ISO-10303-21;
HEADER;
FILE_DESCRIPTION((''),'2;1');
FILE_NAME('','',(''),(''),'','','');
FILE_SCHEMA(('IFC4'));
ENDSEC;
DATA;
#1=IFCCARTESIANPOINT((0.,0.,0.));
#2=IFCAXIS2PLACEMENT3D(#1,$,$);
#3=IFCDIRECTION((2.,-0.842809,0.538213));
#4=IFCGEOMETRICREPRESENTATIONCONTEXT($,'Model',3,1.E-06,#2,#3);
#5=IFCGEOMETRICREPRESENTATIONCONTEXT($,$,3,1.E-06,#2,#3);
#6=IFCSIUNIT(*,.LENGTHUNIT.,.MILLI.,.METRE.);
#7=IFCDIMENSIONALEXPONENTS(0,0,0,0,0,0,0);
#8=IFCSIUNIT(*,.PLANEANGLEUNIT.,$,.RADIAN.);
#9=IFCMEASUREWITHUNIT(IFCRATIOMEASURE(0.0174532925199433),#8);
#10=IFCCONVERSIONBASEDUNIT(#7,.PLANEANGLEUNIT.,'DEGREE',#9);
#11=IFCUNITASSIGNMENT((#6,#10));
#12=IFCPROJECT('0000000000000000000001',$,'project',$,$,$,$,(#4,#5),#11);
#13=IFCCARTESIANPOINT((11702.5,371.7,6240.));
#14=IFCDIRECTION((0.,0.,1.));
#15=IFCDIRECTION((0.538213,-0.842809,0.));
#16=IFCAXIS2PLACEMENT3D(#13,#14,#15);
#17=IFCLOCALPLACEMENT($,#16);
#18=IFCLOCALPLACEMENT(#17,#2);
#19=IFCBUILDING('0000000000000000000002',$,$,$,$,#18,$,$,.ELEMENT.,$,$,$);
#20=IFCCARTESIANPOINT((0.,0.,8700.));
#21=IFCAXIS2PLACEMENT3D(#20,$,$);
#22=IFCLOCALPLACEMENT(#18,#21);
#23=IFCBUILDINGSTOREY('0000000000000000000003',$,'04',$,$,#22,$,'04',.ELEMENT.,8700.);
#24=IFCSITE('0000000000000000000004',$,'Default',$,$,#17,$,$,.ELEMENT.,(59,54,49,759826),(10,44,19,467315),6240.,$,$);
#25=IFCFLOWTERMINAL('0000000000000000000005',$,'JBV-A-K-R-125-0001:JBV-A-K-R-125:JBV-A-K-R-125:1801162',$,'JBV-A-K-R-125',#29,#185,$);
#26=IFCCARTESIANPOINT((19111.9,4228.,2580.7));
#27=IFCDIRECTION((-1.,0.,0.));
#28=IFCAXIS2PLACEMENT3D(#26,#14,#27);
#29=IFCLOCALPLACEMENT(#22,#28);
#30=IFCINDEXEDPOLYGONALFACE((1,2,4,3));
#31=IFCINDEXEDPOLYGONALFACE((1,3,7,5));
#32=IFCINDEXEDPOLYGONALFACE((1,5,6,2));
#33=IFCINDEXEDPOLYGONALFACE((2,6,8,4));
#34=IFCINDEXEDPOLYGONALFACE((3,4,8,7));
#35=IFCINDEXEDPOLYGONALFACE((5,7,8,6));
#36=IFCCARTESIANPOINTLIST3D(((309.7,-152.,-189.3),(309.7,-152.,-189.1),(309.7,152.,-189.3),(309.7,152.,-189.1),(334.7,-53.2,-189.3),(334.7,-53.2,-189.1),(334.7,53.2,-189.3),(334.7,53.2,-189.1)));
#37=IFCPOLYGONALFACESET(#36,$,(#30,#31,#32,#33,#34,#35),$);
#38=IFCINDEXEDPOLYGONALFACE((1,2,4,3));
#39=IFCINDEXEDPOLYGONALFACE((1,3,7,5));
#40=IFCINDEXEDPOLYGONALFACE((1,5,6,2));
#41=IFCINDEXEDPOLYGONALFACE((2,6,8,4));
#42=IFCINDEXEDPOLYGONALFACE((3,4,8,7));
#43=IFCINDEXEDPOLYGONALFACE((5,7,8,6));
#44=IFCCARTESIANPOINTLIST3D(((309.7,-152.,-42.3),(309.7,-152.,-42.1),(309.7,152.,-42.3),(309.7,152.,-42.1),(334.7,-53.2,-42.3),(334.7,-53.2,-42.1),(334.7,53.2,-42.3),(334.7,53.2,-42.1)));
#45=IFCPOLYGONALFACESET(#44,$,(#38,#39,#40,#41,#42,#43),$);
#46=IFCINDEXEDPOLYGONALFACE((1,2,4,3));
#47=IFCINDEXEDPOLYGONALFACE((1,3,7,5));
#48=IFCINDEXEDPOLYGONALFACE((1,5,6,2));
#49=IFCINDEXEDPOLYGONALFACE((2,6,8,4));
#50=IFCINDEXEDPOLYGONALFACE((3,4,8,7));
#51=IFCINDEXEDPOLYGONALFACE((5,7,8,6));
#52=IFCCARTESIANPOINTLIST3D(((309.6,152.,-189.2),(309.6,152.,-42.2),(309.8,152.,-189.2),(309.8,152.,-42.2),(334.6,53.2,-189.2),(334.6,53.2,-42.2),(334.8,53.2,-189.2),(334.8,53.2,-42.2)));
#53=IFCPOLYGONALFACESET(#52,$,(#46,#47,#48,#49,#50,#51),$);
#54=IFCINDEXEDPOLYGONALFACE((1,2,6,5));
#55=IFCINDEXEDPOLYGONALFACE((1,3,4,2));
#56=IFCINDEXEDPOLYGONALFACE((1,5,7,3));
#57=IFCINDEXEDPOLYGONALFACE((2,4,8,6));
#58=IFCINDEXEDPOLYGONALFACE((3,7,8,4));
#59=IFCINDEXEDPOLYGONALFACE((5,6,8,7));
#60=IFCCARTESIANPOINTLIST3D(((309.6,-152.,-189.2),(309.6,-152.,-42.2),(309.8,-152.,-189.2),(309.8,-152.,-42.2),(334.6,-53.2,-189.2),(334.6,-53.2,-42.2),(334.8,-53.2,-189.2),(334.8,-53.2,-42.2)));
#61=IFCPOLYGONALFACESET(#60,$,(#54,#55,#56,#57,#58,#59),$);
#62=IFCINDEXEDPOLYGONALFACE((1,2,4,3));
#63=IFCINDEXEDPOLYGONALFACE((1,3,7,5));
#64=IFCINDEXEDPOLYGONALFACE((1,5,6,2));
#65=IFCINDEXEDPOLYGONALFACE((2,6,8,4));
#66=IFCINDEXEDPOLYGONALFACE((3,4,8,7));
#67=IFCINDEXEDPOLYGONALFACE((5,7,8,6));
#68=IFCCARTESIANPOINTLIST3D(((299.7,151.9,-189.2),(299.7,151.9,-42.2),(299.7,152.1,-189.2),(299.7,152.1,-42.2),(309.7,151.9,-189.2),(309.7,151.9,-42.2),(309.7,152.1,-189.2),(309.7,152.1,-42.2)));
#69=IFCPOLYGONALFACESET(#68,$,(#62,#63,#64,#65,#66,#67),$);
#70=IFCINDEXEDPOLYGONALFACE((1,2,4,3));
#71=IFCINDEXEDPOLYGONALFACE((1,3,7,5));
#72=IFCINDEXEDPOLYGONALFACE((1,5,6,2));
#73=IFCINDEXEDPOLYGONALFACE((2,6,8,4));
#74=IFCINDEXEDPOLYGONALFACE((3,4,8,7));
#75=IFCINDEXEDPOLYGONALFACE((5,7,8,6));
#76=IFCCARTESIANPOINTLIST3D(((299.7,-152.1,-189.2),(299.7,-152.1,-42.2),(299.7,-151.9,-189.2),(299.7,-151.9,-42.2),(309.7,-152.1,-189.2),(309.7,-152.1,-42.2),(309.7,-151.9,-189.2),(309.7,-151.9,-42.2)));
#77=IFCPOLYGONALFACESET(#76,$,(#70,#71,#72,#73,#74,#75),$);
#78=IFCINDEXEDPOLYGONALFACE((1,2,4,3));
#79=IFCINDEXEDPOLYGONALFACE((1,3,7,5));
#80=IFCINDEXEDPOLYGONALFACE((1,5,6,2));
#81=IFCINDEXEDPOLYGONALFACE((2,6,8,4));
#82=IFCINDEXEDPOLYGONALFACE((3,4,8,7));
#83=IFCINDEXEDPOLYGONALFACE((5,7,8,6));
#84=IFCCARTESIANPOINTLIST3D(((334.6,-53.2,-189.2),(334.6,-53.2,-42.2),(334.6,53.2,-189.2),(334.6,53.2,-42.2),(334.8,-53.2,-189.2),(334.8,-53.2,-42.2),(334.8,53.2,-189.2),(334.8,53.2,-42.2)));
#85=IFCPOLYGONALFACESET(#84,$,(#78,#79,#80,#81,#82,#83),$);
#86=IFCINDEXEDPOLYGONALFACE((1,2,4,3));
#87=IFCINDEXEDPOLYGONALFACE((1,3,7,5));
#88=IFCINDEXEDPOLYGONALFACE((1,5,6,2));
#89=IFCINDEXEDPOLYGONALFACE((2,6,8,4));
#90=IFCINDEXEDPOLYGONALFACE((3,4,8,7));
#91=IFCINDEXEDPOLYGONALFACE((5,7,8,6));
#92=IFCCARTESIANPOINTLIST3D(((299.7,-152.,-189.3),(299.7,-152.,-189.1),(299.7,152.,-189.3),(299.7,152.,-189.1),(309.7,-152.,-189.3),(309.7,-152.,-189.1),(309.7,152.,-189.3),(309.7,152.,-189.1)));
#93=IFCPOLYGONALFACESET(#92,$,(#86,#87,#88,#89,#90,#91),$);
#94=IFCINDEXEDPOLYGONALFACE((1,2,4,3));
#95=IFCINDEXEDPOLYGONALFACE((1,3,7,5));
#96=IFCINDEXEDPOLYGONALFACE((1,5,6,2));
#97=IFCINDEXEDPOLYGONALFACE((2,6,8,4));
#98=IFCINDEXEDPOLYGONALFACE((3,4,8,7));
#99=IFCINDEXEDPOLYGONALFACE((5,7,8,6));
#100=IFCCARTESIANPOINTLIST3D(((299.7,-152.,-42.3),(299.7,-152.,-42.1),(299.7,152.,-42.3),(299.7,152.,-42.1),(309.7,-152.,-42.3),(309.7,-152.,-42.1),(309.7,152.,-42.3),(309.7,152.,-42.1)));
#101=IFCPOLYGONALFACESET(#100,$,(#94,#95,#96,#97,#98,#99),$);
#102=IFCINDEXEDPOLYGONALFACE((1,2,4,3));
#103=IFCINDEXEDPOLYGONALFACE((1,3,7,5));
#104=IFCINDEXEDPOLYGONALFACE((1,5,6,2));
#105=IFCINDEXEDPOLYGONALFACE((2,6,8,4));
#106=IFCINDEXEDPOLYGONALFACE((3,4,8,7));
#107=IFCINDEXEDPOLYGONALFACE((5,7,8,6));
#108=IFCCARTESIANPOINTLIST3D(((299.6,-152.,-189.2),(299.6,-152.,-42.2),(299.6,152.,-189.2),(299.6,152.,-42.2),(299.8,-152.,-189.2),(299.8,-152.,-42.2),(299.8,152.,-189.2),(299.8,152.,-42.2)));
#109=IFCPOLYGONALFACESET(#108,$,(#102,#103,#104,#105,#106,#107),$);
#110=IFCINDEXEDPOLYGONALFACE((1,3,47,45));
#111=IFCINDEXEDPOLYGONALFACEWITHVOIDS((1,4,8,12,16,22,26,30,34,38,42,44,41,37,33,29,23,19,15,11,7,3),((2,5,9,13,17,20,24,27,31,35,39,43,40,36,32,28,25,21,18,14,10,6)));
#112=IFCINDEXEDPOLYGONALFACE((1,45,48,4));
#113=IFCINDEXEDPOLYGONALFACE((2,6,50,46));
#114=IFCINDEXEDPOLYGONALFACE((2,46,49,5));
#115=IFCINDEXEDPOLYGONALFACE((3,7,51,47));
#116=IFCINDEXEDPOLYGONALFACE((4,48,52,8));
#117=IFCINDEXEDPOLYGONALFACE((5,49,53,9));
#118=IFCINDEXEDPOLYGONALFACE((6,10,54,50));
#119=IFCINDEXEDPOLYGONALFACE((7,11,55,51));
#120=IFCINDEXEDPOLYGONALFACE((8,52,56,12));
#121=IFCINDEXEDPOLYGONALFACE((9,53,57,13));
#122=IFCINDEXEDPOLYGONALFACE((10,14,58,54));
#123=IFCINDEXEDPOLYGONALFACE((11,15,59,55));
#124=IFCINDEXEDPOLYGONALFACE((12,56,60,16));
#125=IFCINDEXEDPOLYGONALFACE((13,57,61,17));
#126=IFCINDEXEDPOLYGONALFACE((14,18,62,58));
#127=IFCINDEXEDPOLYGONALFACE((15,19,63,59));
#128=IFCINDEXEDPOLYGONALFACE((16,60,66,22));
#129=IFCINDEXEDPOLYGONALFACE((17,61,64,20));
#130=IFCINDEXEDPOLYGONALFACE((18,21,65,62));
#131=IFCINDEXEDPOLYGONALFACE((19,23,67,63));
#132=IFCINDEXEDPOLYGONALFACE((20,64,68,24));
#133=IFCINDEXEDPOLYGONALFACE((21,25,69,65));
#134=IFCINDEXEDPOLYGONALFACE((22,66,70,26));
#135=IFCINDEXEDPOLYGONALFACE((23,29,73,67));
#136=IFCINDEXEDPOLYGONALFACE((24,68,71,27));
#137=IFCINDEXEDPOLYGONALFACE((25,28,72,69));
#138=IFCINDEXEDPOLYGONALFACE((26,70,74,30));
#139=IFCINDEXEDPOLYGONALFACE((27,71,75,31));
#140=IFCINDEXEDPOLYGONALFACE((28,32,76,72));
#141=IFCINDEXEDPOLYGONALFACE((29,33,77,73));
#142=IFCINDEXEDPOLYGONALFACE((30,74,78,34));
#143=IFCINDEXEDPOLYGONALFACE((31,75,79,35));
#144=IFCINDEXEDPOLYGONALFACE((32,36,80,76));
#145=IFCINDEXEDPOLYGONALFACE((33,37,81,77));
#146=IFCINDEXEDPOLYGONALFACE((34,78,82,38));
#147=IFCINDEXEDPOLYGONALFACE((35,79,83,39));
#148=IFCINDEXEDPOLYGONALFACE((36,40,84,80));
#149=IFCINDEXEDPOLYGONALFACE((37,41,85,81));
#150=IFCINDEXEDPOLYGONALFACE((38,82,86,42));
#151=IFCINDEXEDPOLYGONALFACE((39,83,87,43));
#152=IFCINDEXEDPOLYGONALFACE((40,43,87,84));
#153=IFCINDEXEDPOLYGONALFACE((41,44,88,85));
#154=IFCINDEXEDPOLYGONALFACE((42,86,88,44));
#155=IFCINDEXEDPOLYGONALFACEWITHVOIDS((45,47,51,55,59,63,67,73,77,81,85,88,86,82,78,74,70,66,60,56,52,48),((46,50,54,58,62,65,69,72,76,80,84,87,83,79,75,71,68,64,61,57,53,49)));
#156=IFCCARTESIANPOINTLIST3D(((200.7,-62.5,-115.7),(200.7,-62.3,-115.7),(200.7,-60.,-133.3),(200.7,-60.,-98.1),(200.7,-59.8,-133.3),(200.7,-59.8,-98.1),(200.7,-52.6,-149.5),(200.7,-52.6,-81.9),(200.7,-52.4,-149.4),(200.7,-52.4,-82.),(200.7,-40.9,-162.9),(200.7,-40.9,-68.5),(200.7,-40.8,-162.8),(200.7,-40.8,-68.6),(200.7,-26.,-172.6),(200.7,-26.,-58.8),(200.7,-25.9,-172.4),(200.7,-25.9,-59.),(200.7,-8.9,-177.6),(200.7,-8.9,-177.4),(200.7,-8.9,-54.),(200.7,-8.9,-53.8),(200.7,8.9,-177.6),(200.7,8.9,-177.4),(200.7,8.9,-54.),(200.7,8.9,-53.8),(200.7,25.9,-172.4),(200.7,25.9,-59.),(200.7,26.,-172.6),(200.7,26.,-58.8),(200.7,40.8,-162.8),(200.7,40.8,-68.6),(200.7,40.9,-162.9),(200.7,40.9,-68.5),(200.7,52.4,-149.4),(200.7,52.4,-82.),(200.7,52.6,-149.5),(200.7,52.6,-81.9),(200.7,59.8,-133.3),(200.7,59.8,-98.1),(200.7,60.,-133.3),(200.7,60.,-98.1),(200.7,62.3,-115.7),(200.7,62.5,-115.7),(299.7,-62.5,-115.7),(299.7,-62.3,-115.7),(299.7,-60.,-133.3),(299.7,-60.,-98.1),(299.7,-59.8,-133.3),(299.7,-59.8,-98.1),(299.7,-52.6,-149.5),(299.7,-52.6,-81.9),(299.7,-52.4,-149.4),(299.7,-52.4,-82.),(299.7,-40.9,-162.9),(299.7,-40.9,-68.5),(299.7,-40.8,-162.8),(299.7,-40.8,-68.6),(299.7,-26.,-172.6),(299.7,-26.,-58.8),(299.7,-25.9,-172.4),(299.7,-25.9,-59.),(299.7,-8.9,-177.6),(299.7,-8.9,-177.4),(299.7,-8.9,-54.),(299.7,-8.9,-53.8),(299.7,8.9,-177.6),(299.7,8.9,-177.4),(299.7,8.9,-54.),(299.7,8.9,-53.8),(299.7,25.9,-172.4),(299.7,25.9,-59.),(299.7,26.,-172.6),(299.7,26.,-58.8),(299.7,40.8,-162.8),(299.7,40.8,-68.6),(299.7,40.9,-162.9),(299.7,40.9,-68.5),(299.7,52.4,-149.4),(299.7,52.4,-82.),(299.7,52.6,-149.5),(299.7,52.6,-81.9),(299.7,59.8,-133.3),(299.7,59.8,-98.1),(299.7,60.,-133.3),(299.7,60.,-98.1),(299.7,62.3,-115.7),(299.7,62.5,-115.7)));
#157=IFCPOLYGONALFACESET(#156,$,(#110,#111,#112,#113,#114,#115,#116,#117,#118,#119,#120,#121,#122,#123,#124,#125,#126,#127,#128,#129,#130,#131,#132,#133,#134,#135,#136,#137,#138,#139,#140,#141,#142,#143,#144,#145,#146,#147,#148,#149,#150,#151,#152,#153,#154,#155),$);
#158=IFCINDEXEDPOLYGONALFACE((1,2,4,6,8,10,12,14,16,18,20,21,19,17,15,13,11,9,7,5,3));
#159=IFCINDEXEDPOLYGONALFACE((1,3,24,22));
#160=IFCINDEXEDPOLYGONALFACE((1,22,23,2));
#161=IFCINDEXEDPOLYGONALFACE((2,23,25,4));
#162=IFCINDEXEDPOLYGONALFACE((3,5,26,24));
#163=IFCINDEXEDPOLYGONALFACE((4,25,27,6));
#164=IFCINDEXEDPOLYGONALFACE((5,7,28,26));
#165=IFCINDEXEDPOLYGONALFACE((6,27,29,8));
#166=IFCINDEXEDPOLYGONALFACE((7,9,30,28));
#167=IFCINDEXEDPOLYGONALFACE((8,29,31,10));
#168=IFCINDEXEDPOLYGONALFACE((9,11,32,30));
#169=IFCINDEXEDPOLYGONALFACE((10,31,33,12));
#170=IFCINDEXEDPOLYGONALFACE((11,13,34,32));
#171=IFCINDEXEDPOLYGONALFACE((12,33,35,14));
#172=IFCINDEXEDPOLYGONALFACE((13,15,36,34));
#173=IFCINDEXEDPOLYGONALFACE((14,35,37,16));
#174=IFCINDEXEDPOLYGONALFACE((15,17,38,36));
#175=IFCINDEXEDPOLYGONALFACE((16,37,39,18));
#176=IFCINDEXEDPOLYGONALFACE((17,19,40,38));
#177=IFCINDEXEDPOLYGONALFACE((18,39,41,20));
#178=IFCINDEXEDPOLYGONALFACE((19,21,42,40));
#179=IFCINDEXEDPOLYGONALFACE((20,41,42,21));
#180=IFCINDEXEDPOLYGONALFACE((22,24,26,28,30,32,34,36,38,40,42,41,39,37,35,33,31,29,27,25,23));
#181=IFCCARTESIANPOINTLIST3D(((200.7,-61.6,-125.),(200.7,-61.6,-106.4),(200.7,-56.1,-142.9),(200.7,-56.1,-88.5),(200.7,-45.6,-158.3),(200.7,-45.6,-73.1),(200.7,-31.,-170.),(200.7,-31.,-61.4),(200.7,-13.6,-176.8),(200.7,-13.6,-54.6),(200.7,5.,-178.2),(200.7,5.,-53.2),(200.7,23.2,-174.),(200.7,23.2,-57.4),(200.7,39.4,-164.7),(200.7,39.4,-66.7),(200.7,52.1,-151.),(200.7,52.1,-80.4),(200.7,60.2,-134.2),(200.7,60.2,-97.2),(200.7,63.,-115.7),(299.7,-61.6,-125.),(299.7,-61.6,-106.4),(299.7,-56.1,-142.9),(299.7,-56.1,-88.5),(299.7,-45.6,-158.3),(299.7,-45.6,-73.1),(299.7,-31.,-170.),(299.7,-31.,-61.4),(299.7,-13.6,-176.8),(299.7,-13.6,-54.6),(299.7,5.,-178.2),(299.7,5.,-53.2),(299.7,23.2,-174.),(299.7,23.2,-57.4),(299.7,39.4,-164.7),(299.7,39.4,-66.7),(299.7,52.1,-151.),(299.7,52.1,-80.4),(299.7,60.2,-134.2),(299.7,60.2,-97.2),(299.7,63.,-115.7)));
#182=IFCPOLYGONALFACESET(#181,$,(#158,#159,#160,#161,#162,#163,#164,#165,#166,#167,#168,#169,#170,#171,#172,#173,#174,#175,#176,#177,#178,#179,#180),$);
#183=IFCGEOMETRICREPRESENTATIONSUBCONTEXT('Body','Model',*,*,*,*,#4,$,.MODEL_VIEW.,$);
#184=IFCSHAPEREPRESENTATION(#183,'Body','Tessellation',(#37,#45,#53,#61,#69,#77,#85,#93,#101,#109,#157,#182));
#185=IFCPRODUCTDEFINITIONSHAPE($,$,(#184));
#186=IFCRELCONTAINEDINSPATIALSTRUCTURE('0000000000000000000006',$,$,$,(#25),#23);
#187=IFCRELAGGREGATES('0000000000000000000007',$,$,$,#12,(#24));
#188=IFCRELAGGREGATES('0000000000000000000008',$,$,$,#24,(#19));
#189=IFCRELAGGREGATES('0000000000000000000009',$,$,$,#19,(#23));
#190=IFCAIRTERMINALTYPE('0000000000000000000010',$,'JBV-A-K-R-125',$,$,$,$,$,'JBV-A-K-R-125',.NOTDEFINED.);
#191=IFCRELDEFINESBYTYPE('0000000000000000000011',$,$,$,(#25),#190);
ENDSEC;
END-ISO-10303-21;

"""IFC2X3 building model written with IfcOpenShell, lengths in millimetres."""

from ifc_helpers import new_model, entity, si_unit, converted_unit, direction, frame, frame_2d, origin, origin_2d_with_axis, place, context, subcontext, project, spatial, polyline, circle_curve, parameter, trimmed, segment, composite_curve, rectangle, circle, outline, extrude, source, transform, mapped, type_object, type_shapes, element, save


model = new_model("IFC2X3")

# Units and contexts
model_context = context("Model", 3, precision=1e-06, world=origin(), true_north=direction((2.0, -0.842809, 0.538213)))
context_of_model = context(None, 3, precision=1e-06, world=origin(), true_north=direction((2.0, -0.842809, 0.538213)))
body_context = subcontext(model_context, "Body", "Model", "MODEL_VIEW")
ifc_project = project(units=[si_unit("LENGTHUNIT", "METRE", prefix="MILLI"), converted_unit("PLANEANGLEUNIT", "DEGREE", entity("IfcRatioMeasure", 0.0174532925199433), si_unit("PLANEANGLEUNIT", "RADIAN"), dimensions=[0, 0, 0, 0, 0, 0, 0])], contexts=[model_context, context_of_model])

# Site, building, storey
site_placement = place(None, frame((11702.5, 371.7, 6240.0), z_axis=(0.0, 0.0, 1.0), x_axis=(0.538213, -0.842809, 0.0)))
site = spatial("IfcSite", under=ifc_project, at=site_placement, Name="Default", CompositionType="ELEMENT", RefLatitude=(59, 54, 49, 759826), RefLongitude=(10, 44, 19, 467315), RefElevation=6240.0)
building_placement = place(site_placement, origin())
building = spatial("IfcBuilding", under=site, at=building_placement, CompositionType="ELEMENT")
storey_placement = place(building_placement, frame((0.0, 0.0, 8700.0)))
storey = spatial("IfcBuildingStorey", under=building, at=storey_placement, Name="04", LongName="04", CompositionType="ELEMENT", Elevation=8700.0)

# Flow terminal
air_terminal_type_1 = type_object("IfcAirTerminalType", Name="JBV-A-K-R-125", ElementType="JBV-A-K-R-125", PredefinedType="NOTDEFINED")
shared_shape_1 = source(origin(), body_context, "Body", "SweptSolid", [
    extrude(outline(polyline([(-152.0, -12.5), (152.0, -12.5), (53.2, 12.5), (-53.2, 12.5), (-152.0, -12.5)])), frame((322.2, 0.0, -189.3), z_axis=(0.0, 0.0, 1.0), x_axis=(0.0, -1.0, 0.0)), (0.0, 0.0, 1.0), 0.2),
    extrude(outline(polyline([(-152.0, -12.5), (152.0, -12.5), (53.2, 12.5), (-53.2, 12.5), (-152.0, -12.5)])), frame((322.2, 0.0, -42.3), z_axis=(0.0, 0.0, 1.0), x_axis=(0.0, -1.0, 0.0)), (0.0, 0.0, 1.0), 0.2),
    extrude(rectangle(XDim=0.2, YDim=101.9, at=frame_2d((0.0, 0.0), x_axis=(1.0, 0.0))), frame((322.2, 102.6, -189.2), z_axis=(0.0, 0.0, 1.0), x_axis=(0.969446, 0.245305, 0.0)), (0.0, 0.0, 1.0), 147.0),
    extrude(rectangle(XDim=0.2, YDim=101.9, at=frame_2d((0.0, 0.0), x_axis=(1.0, 0.0))), frame((322.2, -102.6, -189.2), z_axis=(0.0, 0.0, 1.0), x_axis=(-0.969446, 0.245305, 0.0)), (0.0, 0.0, 1.0), 147.0),
    extrude(rectangle(XDim=0.2, YDim=10.0, at=frame_2d((0.0, 0.0), x_axis=(1.0, 0.0))), frame((304.7, 152.0, -189.2), z_axis=(0.0, 0.0, 1.0), x_axis=(0.0, 1.0, 0.0)), (0.0, 0.0, 1.0), 147.0),
    extrude(rectangle(XDim=0.2, YDim=10.0, at=frame_2d((0.0, 0.0), x_axis=(1.0, 0.0))), frame((304.7, -152.0, -189.2), z_axis=(0.0, 0.0, 1.0), x_axis=(0.0, 1.0, 0.0)), (0.0, 0.0, 1.0), 147.0),
    extrude(rectangle(XDim=0.2, YDim=106.4, at=frame_2d((0.0, 0.0), x_axis=(1.0, 0.0))), frame((334.7, 0.0, -189.2)), (0.0, 0.0, 1.0), 147.0),
    extrude(rectangle(XDim=304.0, YDim=10.0, at=frame_2d((0.0, 0.0), x_axis=(1.0, 0.0))), frame((304.7, 0.0, -189.3), z_axis=(0.0, 0.0, 1.0), x_axis=(0.0, -1.0, 0.0)), (0.0, 0.0, 1.0), 0.2),
    extrude(rectangle(XDim=304.0, YDim=10.0, at=frame_2d((0.0, 0.0), x_axis=(1.0, 0.0))), frame((304.7, 0.0, -42.3), z_axis=(0.0, 0.0, 1.0), x_axis=(0.0, -1.0, 0.0)), (0.0, 0.0, 1.0), 0.2),
    extrude(rectangle(XDim=0.2, YDim=304.0, at=frame_2d((0.0, 0.0), x_axis=(1.0, 0.0))), frame((299.7, 0.0, -189.2)), (0.0, 0.0, 1.0), 147.0),
    extrude(outline(composite_curve([segment(trimmed(circle_curve(origin_2d_with_axis(), 62.5), [parameter(0.0)], [parameter(180.0)], True, "PARAMETER"), True, "CONTINUOUS"), segment(trimmed(circle_curve(origin_2d_with_axis(), 62.5), [parameter(180.0)], [parameter(360.0)], True, "PARAMETER"), True, "CONTINUOUS")], self_intersect=False), holes=[composite_curve([segment(trimmed(circle_curve(origin_2d_with_axis(), 62.3), [parameter(180.0)], [parameter(360.0)], True, "PARAMETER"), False, "CONTINUOUS"), segment(trimmed(circle_curve(origin_2d_with_axis(), 62.3), [parameter(0.0)], [parameter(180.0)], True, "PARAMETER"), False, "CONTINUOUS")], self_intersect=False)]), frame((200.7, 0.0, -115.7), z_axis=(1.0, 0.0, 0.0), x_axis=(0.0, 1.0, 0.0)), (0.0, 0.0, 1.0), 99.0),
    extrude(circle(Radius=62.6, at=frame_2d((0.0, 0.0), x_axis=(1.0, 0.0))), frame((200.7, 0.3, -115.7), z_axis=(1.0, 0.0, 0.0), x_axis=(0.0, 1.0, 0.0)), (0.0, 0.0, 1.0), 99.0),
])
type_shapes(air_terminal_type_1, [shared_shape_1])
flow_terminal_1_placement = place(storey_placement, frame((19111.9, 4228.0, 2580.7), z_axis=(0.0, 0.0, 1.0), x_axis=(-1.0, 0.0, 0.0)))
element("IfcFlowTerminal", 1, at=flow_terminal_1_placement, inside=storey, type_object=air_terminal_type_1, Name="JBV-A-K-R-125-0001:JBV-A-K-R-125:JBV-A-K-R-125:1801162", ObjectType="JBV-A-K-R-125", context=body_context, shape_type="MappedRepresentation", body=[
    mapped(shared_shape_1, transform((0.0, 0.0, 0.0), scale=1.0)),
])

save(model, "model.ifc")
